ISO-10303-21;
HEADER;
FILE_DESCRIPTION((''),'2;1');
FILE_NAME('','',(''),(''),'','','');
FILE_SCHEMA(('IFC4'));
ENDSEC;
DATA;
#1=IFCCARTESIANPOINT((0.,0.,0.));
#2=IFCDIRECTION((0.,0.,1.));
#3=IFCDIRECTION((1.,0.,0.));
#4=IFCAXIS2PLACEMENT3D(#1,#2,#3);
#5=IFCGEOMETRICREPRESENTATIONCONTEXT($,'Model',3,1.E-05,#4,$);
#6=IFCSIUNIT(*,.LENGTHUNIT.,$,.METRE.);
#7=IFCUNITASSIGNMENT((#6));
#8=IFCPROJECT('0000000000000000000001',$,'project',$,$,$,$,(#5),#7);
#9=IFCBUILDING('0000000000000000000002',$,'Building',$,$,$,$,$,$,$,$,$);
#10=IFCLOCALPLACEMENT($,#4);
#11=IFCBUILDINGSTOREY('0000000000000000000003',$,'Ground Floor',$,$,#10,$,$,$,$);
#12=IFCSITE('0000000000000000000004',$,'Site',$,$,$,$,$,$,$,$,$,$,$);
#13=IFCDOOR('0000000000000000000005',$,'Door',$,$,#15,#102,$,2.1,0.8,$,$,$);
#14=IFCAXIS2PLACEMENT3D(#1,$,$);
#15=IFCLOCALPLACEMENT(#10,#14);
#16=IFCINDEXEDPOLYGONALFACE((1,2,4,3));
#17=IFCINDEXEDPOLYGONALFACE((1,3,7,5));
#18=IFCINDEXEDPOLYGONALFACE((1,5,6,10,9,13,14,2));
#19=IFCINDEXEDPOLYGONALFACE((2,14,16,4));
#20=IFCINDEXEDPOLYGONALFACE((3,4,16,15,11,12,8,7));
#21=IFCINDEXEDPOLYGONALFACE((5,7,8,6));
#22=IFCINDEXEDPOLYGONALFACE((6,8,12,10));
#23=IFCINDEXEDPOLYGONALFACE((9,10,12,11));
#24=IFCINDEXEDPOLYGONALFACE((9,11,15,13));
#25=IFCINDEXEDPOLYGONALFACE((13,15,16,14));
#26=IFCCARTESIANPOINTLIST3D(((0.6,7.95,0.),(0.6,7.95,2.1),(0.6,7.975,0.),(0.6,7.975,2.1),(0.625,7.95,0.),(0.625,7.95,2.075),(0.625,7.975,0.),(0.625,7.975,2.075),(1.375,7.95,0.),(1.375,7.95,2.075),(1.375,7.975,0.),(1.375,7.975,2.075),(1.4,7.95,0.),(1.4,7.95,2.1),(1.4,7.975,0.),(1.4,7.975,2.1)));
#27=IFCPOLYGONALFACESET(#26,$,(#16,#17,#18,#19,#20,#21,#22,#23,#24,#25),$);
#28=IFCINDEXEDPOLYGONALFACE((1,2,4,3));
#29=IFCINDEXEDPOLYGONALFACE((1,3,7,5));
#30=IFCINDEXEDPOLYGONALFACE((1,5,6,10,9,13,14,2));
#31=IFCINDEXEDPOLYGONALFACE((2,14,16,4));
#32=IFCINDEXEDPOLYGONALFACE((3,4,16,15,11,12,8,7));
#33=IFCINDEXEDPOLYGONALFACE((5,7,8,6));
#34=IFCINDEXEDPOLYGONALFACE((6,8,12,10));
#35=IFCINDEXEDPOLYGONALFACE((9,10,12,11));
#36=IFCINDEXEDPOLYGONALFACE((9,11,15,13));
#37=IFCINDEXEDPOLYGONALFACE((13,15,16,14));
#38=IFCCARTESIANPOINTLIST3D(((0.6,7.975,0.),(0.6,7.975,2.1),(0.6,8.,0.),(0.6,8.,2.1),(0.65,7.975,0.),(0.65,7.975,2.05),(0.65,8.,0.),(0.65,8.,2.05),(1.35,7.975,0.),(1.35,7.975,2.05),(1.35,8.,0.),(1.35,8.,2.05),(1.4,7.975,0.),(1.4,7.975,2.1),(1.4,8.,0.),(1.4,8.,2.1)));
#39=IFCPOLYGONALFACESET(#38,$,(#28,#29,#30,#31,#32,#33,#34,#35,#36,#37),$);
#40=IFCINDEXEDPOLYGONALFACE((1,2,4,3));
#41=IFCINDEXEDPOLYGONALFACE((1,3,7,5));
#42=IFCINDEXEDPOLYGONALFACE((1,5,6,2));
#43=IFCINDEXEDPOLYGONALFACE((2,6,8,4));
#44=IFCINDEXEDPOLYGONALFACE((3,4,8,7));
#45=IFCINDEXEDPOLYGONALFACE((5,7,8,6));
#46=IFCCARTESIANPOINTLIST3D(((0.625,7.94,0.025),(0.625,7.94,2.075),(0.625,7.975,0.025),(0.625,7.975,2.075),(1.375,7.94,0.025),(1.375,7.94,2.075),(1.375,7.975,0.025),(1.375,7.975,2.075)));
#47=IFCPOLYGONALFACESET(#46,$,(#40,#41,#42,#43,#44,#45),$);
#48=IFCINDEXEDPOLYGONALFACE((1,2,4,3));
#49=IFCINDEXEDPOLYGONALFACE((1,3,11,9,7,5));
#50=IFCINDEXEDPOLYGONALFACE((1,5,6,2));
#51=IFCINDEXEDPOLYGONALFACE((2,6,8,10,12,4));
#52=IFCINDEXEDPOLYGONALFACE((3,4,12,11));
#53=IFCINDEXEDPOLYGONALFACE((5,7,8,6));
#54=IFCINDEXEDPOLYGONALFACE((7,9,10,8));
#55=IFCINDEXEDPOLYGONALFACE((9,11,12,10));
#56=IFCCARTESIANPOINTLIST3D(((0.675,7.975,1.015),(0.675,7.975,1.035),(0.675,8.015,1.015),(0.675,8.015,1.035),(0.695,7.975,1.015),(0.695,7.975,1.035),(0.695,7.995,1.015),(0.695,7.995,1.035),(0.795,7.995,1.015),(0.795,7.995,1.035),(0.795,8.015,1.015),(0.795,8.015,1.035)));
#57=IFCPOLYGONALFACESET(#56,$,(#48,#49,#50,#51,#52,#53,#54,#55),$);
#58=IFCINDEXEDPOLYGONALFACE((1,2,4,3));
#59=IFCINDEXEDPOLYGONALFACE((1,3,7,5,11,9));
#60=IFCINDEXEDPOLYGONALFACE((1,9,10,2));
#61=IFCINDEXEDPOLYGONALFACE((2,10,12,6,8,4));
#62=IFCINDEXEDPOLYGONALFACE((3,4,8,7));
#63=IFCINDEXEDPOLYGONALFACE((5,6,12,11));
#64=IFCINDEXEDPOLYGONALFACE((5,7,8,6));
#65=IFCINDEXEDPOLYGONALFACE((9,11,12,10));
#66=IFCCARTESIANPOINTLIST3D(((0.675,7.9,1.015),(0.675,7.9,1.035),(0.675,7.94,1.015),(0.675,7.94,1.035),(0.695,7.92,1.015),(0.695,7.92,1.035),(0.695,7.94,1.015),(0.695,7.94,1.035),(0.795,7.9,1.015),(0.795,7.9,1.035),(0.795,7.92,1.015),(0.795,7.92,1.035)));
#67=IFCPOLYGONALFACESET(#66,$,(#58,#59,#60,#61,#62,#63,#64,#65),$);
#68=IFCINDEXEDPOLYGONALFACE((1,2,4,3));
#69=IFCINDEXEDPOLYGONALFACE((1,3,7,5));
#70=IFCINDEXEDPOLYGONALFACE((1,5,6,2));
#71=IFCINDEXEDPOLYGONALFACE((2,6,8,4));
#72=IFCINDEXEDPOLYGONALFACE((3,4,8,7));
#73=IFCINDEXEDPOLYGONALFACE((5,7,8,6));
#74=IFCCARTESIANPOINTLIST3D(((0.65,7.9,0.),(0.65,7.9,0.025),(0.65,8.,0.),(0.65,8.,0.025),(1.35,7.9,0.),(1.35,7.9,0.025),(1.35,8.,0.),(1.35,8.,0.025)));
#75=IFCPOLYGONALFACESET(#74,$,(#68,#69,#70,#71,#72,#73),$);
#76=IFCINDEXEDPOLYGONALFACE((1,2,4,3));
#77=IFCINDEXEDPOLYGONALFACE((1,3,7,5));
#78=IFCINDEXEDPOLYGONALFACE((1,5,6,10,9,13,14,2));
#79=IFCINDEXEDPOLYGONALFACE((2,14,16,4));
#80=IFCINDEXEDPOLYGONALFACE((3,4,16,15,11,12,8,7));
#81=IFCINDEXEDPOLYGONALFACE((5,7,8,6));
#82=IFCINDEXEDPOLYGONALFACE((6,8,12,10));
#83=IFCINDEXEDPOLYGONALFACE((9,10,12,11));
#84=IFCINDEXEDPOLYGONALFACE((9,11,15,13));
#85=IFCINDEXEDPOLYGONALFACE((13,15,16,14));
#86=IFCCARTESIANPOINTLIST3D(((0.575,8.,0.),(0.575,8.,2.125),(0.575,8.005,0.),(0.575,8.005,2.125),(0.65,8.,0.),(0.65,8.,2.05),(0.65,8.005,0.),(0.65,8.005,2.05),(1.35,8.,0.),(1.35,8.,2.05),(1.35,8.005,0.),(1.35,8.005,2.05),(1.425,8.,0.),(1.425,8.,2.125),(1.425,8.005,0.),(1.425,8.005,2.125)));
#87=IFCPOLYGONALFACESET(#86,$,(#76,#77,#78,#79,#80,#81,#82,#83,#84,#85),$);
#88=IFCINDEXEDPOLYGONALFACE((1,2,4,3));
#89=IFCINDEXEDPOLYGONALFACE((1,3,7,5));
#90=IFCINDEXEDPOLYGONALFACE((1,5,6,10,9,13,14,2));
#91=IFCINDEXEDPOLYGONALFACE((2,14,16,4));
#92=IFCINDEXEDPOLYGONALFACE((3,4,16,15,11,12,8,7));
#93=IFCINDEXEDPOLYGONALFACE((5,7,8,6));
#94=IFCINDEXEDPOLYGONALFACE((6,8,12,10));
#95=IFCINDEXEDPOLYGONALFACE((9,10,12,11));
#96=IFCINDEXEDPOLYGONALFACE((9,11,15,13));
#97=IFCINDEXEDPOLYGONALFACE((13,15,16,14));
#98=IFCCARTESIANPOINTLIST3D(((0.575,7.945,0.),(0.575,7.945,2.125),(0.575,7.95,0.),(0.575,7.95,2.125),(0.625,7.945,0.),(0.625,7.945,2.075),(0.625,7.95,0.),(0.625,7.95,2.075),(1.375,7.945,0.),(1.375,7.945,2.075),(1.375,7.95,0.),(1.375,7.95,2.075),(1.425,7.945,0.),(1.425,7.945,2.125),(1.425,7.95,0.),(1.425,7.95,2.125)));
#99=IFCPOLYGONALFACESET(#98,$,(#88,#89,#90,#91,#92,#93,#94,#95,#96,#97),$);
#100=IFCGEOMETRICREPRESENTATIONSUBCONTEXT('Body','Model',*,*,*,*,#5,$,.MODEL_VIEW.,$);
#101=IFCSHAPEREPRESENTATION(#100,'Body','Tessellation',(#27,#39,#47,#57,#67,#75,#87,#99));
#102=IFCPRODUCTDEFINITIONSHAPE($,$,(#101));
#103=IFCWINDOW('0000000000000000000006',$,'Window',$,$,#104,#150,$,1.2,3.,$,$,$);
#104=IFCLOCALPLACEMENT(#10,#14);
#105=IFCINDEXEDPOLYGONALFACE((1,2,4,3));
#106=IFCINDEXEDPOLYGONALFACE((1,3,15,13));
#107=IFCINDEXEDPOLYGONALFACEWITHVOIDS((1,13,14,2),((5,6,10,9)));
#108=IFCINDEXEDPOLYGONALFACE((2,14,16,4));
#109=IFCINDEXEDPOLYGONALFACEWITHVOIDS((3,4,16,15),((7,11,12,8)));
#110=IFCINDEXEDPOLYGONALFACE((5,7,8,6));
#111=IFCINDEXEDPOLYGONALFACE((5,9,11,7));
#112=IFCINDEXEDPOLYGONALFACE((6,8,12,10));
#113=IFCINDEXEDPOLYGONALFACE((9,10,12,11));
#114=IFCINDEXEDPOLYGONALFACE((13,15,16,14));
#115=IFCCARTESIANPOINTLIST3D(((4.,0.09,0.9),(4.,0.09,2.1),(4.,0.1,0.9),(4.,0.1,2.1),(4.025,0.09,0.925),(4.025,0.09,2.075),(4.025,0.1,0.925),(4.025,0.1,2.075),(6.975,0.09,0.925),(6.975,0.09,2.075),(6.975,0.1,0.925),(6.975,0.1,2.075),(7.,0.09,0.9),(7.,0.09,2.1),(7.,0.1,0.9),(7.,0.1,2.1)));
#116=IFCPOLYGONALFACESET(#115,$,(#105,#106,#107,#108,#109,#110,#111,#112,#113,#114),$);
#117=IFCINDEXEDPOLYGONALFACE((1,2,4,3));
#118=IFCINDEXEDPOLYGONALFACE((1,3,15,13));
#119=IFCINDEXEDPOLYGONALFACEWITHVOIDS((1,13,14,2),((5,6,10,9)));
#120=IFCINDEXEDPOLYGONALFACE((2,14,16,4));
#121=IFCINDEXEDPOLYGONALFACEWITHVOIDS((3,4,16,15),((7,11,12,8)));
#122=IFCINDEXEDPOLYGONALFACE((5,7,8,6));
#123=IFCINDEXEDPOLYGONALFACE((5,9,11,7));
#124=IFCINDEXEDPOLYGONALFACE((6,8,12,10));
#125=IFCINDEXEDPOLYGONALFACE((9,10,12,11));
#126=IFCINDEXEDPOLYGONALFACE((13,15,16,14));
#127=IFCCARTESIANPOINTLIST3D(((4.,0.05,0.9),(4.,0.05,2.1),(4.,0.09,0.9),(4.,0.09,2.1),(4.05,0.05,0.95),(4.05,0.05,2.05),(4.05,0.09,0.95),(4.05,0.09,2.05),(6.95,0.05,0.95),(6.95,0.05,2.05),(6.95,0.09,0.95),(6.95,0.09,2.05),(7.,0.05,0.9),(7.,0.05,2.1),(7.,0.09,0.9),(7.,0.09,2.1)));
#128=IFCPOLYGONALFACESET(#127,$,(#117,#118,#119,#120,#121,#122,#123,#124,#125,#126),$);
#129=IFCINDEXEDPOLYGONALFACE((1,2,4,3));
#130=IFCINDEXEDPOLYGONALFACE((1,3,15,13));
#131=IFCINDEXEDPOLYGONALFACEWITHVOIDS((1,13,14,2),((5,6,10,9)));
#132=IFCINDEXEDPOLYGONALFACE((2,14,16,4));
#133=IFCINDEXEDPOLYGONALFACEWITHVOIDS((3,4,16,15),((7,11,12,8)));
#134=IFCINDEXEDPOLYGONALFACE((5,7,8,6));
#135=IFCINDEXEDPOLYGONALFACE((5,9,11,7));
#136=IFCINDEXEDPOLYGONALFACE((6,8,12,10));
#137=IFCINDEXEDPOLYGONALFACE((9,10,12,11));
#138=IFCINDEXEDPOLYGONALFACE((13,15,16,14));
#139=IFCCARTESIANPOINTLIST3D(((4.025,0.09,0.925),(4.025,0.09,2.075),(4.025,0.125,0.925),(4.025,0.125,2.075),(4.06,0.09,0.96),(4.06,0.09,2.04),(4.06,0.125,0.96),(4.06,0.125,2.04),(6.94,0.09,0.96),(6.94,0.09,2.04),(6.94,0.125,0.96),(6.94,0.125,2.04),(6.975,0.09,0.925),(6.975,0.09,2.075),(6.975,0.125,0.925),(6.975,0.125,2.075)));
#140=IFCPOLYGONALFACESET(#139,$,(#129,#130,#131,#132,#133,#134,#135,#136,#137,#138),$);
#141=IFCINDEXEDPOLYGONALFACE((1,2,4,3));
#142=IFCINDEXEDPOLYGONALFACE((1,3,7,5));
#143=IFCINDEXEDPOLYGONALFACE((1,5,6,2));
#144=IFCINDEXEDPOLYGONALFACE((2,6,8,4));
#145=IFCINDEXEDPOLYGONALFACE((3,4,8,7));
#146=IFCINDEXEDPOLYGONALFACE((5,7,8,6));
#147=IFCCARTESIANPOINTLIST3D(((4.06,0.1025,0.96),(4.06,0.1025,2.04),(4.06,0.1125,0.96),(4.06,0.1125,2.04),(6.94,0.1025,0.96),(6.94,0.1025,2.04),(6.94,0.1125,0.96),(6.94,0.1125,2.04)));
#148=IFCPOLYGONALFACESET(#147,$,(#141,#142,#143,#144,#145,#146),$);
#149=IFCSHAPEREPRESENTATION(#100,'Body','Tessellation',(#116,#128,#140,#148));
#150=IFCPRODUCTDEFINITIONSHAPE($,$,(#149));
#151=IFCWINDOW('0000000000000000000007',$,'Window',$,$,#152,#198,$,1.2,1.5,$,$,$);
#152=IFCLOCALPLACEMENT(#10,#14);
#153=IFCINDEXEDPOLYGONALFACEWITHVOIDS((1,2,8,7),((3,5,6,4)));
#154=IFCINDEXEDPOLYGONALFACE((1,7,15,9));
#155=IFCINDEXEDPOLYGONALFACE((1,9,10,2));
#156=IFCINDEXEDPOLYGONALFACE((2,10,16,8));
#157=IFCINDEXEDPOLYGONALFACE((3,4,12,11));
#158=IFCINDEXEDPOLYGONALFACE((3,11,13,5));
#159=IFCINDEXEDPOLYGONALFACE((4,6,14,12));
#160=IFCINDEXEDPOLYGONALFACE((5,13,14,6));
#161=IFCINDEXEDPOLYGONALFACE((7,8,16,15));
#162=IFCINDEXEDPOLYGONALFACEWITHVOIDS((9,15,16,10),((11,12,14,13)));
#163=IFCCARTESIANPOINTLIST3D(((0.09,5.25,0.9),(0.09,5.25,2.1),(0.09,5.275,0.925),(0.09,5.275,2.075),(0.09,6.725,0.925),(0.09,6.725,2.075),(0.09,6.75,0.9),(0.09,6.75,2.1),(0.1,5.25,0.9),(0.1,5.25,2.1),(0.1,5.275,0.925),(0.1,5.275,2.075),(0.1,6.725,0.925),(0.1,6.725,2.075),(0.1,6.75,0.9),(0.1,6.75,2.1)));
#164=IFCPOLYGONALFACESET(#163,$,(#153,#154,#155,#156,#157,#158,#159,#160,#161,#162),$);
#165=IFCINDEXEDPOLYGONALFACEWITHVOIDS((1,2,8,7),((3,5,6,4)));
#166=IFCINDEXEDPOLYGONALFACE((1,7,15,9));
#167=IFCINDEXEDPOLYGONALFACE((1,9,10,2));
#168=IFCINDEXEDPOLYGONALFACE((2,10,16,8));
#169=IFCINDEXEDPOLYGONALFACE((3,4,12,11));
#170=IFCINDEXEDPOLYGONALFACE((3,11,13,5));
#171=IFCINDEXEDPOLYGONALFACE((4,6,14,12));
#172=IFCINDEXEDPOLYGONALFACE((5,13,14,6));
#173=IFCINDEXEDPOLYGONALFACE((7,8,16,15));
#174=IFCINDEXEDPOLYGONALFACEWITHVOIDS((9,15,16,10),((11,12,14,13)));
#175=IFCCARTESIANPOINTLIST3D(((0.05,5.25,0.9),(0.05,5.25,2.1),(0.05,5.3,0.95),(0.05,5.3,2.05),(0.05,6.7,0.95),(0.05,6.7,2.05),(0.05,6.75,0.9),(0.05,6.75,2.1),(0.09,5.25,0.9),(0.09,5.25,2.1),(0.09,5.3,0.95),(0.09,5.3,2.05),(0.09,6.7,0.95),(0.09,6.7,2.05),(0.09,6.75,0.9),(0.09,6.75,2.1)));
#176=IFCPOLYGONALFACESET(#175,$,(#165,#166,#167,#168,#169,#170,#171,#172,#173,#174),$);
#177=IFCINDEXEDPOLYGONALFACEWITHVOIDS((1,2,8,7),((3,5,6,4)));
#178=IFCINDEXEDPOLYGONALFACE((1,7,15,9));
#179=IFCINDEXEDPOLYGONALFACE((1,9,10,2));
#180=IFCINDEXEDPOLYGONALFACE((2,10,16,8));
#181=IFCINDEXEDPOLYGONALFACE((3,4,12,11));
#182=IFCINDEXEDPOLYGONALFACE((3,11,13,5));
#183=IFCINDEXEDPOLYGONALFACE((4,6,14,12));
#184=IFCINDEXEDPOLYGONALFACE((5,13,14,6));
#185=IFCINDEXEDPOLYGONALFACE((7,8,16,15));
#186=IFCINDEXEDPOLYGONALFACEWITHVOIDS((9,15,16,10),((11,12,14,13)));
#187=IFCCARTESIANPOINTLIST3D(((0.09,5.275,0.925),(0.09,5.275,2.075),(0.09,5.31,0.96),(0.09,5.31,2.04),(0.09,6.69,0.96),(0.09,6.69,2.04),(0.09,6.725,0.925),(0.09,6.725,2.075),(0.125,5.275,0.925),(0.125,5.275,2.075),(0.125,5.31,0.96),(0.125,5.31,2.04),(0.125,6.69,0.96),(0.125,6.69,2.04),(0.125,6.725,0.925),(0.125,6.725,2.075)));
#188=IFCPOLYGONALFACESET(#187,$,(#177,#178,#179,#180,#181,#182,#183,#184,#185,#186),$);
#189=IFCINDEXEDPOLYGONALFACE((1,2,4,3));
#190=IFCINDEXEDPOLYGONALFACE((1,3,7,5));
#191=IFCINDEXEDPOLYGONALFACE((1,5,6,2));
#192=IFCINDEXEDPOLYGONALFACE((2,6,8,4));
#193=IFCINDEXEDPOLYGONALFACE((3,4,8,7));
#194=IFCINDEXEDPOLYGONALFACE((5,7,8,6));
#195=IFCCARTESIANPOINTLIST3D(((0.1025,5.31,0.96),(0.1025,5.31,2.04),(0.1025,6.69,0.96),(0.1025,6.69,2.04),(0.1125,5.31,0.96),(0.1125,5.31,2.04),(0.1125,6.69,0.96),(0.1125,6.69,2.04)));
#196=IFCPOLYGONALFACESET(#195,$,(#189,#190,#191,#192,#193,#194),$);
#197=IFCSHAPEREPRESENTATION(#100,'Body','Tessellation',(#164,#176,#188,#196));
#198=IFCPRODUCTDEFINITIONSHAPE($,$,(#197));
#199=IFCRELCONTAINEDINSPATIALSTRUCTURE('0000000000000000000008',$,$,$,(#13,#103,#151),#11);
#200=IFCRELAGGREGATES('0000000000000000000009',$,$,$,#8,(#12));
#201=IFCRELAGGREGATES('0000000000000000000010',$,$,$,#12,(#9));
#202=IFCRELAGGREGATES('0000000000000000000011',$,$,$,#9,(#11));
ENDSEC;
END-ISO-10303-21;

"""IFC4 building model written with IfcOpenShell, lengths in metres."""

from ifc_helpers import new_model, si_unit, frame, origin_with_axes, place, context, subcontext, project, spatial, line, indexed_curve, outline, extrude, element, save


model = new_model("IFC4")

# Units and contexts
model_context = context("Model", 3, precision=1e-05, world=origin_with_axes())
body_context = subcontext(model_context, "Body", "Model", "MODEL_VIEW")
ifc_project = project(units=[si_unit("LENGTHUNIT", "METRE")], contexts=[model_context])

# Site, building, storey
site = spatial("IfcSite", under=ifc_project, Name="Site")
building = spatial("IfcBuilding", under=site, Name="Building")
storey_placement = place(None, origin_with_axes())
storey = spatial("IfcBuildingStorey", under=building, at=storey_placement, Name="Ground Floor")

# Door
door_1_placement = place(storey_placement, frame((1.4, 8.0, 0.0), z_axis=(0.0, 0.0, 1.0), x_axis=(-1.0, 0.0, 0.0)))
element("IfcDoor", 1, at=door_1_placement, inside=storey, Name="Door", OverallHeight=2.1, OverallWidth=0.8, context=body_context, shape_type="SweptSolid", body=[
    extrude(outline(indexed_curve([(0.0, 0.0), (0.0, 2.1), (0.8, 2.1), (0.8, 0.0), (0.775, 0.0), (0.775, 2.075), (0.025, 2.075), (0.025, 0.0)], segments=[line(1, 2, 3, 4, 5, 6, 7, 8, 1)])), frame((0.0, 0.025, 0.0), z_axis=(0.0, -1.0, 0.0), x_axis=(1.0, 0.0, 0.0)), (0.0, 0.0, -1.0), 0.025),
    extrude(outline(indexed_curve([(0.0, 0.0), (0.0, 2.1), (0.8, 2.1), (0.8, 0.0), (0.75, 0.0), (0.75, 2.05), (0.05, 2.05), (0.05, 0.0)], segments=[line(1, 2, 3, 4, 5, 6, 7, 8, 1)])), frame((0.0, 0.0, 0.0), z_axis=(0.0, -1.0, 0.0), x_axis=(1.0, 0.0, 0.0)), (0.0, 0.0, -1.0), 0.025),
    extrude(outline(indexed_curve([(0.0, 0.0), (0.75, 0.0), (0.75, 0.035), (0.0, 0.035)], segments=[line(1, 2, 3, 4, 1)])), frame((0.025, 0.025, 0.025), z_axis=(0.0, 0.0, 1.0), x_axis=(1.0, 0.0, 0.0)), (0.0, 0.0, 1.0), 2.05),
    extrude(outline(indexed_curve([(0.0, 0.0), (0.0, -0.04), (-0.12, -0.04), (-0.12, -0.02), (-0.02, -0.02), (-0.02, 0.0)], segments=[line(1, 2, 3, 4, 5, 6, 1)])), frame((0.725, 0.025, 1.015), z_axis=(0.0, 0.0, 1.0), x_axis=(1.0, 0.0, 0.0)), (0.0, 0.0, 1.0), 0.02),
    extrude(outline(indexed_curve([(0.0, 0.0), (0.0, 0.04), (-0.12, 0.04), (-0.12, 0.02), (-0.02, 0.02), (-0.02, 0.0)], segments=[line(1, 2, 3, 4, 5, 6, 1)])), frame((0.725, 0.06, 1.015), z_axis=(0.0, 0.0, 1.0), x_axis=(1.0, 0.0, 0.0)), (0.0, 0.0, 1.0), 0.02),
    extrude(outline(indexed_curve([(0.0, 0.0), (0.7, 0.0), (0.7, 0.1), (0.0, 0.1)], segments=[line(1, 2, 3, 4, 1)])), frame((0.05, 0.0, 0.0), z_axis=(0.0, 0.0, 1.0), x_axis=(1.0, 0.0, 0.0)), (0.0, 0.0, 1.0), 0.025),
    extrude(outline(indexed_curve([(0.0, 0.0), (0.0, 2.125), (0.85, 2.125), (0.85, 0.0), (0.775, 0.0), (0.775, 2.05), (0.075, 2.05), (0.075, 0.0)], segments=[line(1, 2, 3, 4, 5, 6, 7, 8, 1)])), frame((-0.025, -0.005, 0.0), z_axis=(0.0, -1.0, 0.0), x_axis=(1.0, 0.0, 0.0)), (0.0, 0.0, -1.0), 0.005),
    extrude(outline(indexed_curve([(0.0, 0.0), (0.0, 2.125), (0.85, 2.125), (0.85, 0.0), (0.8, 0.0), (0.8, 2.075), (0.05, 2.075), (0.05, 0.0)], segments=[line(1, 2, 3, 4, 5, 6, 7, 8, 1)])), frame((-0.025, 0.05, 0.0), z_axis=(0.0, -1.0, 0.0), x_axis=(1.0, 0.0, 0.0)), (0.0, 0.0, -1.0), 0.005),
])

# Windows
window_1_placement = place(storey_placement, frame((4.0, 0.0, 0.9), z_axis=(0.0, 0.0, 1.0), x_axis=(1.0, 0.0, 0.0)))
element("IfcWindow", 2, at=window_1_placement, inside=storey, Name="Window", OverallHeight=1.2, OverallWidth=3.0, context=body_context, shape_type="SweptSolid", body=[
    extrude(outline(indexed_curve([(0.0, 0.0), (3.0, 0.0), (3.0, 1.2), (0.0, 1.2)], segments=[line(1, 2, 3, 4, 1)]), holes=[indexed_curve([(0.025, 0.025), (2.975, 0.025), (2.975, 1.175), (0.025, 1.175)], segments=[line(1, 2, 3, 4, 1)])]), frame((0.0, 0.09, 0.0), z_axis=(0.0, -1.0, 0.0), x_axis=(1.0, 0.0, 0.0)), (0.0, 0.0, -1.0), 0.01),
    extrude(outline(indexed_curve([(0.0, 0.0), (3.0, 0.0), (3.0, 1.2), (0.0, 1.2)], segments=[line(1, 2, 3, 4, 1)]), holes=[indexed_curve([(0.05, 0.05), (2.95, 0.05), (2.95, 1.15), (0.05, 1.15)], segments=[line(1, 2, 3, 4, 1)])]), frame((0.0, 0.05, 0.0), z_axis=(0.0, -1.0, 0.0), x_axis=(1.0, 0.0, 0.0)), (0.0, 0.0, -1.0), 0.04),
    extrude(outline(indexed_curve([(0.0, 0.0), (2.95, 0.0), (2.95, 1.15), (0.0, 1.15)], segments=[line(1, 2, 3, 4, 1)]), holes=[indexed_curve([(0.035, 0.035), (2.915, 0.035), (2.915, 1.115), (0.035, 1.115)], segments=[line(1, 2, 3, 4, 1)])]), frame((0.025, 0.09, 0.025), z_axis=(0.0, -1.0, 0.0), x_axis=(1.0, 0.0, 0.0)), (0.0, 0.0, -1.0), 0.035),
    extrude(outline(indexed_curve([(0.035, 0.035), (2.915, 0.035), (2.915, 1.115), (0.035, 1.115)], segments=[line(1, 2, 3, 4, 1)])), frame((0.025, 0.1025, 0.025), z_axis=(0.0, -1.0, 0.0), x_axis=(1.0, 0.0, 0.0)), (0.0, 0.0, -1.0), 0.01),
])
window_2_placement = place(storey_placement, frame((0.0, 6.75, 0.9), z_axis=(0.0, 0.0, 1.0), x_axis=(0.0, -1.0, 0.0)))
element("IfcWindow", 3, at=window_2_placement, inside=storey, Name="Window", OverallHeight=1.2, OverallWidth=1.5, context=body_context, shape_type="SweptSolid", body=[
    extrude(outline(indexed_curve([(0.0, 0.0), (1.5, 0.0), (1.5, 1.2), (0.0, 1.2)], segments=[line(1, 2, 3, 4, 1)]), holes=[indexed_curve([(0.025, 0.025), (1.475, 0.025), (1.475, 1.175), (0.025, 1.175)], segments=[line(1, 2, 3, 4, 1)])]), frame((0.0, 0.09, 0.0), z_axis=(0.0, -1.0, 0.0), x_axis=(1.0, 0.0, 0.0)), (0.0, 0.0, -1.0), 0.01),
    extrude(outline(indexed_curve([(0.0, 0.0), (1.5, 0.0), (1.5, 1.2), (0.0, 1.2)], segments=[line(1, 2, 3, 4, 1)]), holes=[indexed_curve([(0.05, 0.05), (1.45, 0.05), (1.45, 1.15), (0.05, 1.15)], segments=[line(1, 2, 3, 4, 1)])]), frame((0.0, 0.05, 0.0), z_axis=(0.0, -1.0, 0.0), x_axis=(1.0, 0.0, 0.0)), (0.0, 0.0, -1.0), 0.04),
    extrude(outline(indexed_curve([(0.0, 0.0), (1.45, 0.0), (1.45, 1.15), (0.0, 1.15)], segments=[line(1, 2, 3, 4, 1)]), holes=[indexed_curve([(0.035, 0.035), (1.415, 0.035), (1.415, 1.115), (0.035, 1.115)], segments=[line(1, 2, 3, 4, 1)])]), frame((0.025, 0.09, 0.025), z_axis=(0.0, -1.0, 0.0), x_axis=(1.0, 0.0, 0.0)), (0.0, 0.0, -1.0), 0.035),
    extrude(outline(indexed_curve([(0.035, 0.035), (1.415, 0.035), (1.415, 1.115), (0.035, 1.115)], segments=[line(1, 2, 3, 4, 1)])), frame((0.025, 0.1025, 0.025), z_axis=(0.0, -1.0, 0.0), x_axis=(1.0, 0.0, 0.0)), (0.0, 0.0, -1.0), 0.01),
])

save(model, "model.ifc")
